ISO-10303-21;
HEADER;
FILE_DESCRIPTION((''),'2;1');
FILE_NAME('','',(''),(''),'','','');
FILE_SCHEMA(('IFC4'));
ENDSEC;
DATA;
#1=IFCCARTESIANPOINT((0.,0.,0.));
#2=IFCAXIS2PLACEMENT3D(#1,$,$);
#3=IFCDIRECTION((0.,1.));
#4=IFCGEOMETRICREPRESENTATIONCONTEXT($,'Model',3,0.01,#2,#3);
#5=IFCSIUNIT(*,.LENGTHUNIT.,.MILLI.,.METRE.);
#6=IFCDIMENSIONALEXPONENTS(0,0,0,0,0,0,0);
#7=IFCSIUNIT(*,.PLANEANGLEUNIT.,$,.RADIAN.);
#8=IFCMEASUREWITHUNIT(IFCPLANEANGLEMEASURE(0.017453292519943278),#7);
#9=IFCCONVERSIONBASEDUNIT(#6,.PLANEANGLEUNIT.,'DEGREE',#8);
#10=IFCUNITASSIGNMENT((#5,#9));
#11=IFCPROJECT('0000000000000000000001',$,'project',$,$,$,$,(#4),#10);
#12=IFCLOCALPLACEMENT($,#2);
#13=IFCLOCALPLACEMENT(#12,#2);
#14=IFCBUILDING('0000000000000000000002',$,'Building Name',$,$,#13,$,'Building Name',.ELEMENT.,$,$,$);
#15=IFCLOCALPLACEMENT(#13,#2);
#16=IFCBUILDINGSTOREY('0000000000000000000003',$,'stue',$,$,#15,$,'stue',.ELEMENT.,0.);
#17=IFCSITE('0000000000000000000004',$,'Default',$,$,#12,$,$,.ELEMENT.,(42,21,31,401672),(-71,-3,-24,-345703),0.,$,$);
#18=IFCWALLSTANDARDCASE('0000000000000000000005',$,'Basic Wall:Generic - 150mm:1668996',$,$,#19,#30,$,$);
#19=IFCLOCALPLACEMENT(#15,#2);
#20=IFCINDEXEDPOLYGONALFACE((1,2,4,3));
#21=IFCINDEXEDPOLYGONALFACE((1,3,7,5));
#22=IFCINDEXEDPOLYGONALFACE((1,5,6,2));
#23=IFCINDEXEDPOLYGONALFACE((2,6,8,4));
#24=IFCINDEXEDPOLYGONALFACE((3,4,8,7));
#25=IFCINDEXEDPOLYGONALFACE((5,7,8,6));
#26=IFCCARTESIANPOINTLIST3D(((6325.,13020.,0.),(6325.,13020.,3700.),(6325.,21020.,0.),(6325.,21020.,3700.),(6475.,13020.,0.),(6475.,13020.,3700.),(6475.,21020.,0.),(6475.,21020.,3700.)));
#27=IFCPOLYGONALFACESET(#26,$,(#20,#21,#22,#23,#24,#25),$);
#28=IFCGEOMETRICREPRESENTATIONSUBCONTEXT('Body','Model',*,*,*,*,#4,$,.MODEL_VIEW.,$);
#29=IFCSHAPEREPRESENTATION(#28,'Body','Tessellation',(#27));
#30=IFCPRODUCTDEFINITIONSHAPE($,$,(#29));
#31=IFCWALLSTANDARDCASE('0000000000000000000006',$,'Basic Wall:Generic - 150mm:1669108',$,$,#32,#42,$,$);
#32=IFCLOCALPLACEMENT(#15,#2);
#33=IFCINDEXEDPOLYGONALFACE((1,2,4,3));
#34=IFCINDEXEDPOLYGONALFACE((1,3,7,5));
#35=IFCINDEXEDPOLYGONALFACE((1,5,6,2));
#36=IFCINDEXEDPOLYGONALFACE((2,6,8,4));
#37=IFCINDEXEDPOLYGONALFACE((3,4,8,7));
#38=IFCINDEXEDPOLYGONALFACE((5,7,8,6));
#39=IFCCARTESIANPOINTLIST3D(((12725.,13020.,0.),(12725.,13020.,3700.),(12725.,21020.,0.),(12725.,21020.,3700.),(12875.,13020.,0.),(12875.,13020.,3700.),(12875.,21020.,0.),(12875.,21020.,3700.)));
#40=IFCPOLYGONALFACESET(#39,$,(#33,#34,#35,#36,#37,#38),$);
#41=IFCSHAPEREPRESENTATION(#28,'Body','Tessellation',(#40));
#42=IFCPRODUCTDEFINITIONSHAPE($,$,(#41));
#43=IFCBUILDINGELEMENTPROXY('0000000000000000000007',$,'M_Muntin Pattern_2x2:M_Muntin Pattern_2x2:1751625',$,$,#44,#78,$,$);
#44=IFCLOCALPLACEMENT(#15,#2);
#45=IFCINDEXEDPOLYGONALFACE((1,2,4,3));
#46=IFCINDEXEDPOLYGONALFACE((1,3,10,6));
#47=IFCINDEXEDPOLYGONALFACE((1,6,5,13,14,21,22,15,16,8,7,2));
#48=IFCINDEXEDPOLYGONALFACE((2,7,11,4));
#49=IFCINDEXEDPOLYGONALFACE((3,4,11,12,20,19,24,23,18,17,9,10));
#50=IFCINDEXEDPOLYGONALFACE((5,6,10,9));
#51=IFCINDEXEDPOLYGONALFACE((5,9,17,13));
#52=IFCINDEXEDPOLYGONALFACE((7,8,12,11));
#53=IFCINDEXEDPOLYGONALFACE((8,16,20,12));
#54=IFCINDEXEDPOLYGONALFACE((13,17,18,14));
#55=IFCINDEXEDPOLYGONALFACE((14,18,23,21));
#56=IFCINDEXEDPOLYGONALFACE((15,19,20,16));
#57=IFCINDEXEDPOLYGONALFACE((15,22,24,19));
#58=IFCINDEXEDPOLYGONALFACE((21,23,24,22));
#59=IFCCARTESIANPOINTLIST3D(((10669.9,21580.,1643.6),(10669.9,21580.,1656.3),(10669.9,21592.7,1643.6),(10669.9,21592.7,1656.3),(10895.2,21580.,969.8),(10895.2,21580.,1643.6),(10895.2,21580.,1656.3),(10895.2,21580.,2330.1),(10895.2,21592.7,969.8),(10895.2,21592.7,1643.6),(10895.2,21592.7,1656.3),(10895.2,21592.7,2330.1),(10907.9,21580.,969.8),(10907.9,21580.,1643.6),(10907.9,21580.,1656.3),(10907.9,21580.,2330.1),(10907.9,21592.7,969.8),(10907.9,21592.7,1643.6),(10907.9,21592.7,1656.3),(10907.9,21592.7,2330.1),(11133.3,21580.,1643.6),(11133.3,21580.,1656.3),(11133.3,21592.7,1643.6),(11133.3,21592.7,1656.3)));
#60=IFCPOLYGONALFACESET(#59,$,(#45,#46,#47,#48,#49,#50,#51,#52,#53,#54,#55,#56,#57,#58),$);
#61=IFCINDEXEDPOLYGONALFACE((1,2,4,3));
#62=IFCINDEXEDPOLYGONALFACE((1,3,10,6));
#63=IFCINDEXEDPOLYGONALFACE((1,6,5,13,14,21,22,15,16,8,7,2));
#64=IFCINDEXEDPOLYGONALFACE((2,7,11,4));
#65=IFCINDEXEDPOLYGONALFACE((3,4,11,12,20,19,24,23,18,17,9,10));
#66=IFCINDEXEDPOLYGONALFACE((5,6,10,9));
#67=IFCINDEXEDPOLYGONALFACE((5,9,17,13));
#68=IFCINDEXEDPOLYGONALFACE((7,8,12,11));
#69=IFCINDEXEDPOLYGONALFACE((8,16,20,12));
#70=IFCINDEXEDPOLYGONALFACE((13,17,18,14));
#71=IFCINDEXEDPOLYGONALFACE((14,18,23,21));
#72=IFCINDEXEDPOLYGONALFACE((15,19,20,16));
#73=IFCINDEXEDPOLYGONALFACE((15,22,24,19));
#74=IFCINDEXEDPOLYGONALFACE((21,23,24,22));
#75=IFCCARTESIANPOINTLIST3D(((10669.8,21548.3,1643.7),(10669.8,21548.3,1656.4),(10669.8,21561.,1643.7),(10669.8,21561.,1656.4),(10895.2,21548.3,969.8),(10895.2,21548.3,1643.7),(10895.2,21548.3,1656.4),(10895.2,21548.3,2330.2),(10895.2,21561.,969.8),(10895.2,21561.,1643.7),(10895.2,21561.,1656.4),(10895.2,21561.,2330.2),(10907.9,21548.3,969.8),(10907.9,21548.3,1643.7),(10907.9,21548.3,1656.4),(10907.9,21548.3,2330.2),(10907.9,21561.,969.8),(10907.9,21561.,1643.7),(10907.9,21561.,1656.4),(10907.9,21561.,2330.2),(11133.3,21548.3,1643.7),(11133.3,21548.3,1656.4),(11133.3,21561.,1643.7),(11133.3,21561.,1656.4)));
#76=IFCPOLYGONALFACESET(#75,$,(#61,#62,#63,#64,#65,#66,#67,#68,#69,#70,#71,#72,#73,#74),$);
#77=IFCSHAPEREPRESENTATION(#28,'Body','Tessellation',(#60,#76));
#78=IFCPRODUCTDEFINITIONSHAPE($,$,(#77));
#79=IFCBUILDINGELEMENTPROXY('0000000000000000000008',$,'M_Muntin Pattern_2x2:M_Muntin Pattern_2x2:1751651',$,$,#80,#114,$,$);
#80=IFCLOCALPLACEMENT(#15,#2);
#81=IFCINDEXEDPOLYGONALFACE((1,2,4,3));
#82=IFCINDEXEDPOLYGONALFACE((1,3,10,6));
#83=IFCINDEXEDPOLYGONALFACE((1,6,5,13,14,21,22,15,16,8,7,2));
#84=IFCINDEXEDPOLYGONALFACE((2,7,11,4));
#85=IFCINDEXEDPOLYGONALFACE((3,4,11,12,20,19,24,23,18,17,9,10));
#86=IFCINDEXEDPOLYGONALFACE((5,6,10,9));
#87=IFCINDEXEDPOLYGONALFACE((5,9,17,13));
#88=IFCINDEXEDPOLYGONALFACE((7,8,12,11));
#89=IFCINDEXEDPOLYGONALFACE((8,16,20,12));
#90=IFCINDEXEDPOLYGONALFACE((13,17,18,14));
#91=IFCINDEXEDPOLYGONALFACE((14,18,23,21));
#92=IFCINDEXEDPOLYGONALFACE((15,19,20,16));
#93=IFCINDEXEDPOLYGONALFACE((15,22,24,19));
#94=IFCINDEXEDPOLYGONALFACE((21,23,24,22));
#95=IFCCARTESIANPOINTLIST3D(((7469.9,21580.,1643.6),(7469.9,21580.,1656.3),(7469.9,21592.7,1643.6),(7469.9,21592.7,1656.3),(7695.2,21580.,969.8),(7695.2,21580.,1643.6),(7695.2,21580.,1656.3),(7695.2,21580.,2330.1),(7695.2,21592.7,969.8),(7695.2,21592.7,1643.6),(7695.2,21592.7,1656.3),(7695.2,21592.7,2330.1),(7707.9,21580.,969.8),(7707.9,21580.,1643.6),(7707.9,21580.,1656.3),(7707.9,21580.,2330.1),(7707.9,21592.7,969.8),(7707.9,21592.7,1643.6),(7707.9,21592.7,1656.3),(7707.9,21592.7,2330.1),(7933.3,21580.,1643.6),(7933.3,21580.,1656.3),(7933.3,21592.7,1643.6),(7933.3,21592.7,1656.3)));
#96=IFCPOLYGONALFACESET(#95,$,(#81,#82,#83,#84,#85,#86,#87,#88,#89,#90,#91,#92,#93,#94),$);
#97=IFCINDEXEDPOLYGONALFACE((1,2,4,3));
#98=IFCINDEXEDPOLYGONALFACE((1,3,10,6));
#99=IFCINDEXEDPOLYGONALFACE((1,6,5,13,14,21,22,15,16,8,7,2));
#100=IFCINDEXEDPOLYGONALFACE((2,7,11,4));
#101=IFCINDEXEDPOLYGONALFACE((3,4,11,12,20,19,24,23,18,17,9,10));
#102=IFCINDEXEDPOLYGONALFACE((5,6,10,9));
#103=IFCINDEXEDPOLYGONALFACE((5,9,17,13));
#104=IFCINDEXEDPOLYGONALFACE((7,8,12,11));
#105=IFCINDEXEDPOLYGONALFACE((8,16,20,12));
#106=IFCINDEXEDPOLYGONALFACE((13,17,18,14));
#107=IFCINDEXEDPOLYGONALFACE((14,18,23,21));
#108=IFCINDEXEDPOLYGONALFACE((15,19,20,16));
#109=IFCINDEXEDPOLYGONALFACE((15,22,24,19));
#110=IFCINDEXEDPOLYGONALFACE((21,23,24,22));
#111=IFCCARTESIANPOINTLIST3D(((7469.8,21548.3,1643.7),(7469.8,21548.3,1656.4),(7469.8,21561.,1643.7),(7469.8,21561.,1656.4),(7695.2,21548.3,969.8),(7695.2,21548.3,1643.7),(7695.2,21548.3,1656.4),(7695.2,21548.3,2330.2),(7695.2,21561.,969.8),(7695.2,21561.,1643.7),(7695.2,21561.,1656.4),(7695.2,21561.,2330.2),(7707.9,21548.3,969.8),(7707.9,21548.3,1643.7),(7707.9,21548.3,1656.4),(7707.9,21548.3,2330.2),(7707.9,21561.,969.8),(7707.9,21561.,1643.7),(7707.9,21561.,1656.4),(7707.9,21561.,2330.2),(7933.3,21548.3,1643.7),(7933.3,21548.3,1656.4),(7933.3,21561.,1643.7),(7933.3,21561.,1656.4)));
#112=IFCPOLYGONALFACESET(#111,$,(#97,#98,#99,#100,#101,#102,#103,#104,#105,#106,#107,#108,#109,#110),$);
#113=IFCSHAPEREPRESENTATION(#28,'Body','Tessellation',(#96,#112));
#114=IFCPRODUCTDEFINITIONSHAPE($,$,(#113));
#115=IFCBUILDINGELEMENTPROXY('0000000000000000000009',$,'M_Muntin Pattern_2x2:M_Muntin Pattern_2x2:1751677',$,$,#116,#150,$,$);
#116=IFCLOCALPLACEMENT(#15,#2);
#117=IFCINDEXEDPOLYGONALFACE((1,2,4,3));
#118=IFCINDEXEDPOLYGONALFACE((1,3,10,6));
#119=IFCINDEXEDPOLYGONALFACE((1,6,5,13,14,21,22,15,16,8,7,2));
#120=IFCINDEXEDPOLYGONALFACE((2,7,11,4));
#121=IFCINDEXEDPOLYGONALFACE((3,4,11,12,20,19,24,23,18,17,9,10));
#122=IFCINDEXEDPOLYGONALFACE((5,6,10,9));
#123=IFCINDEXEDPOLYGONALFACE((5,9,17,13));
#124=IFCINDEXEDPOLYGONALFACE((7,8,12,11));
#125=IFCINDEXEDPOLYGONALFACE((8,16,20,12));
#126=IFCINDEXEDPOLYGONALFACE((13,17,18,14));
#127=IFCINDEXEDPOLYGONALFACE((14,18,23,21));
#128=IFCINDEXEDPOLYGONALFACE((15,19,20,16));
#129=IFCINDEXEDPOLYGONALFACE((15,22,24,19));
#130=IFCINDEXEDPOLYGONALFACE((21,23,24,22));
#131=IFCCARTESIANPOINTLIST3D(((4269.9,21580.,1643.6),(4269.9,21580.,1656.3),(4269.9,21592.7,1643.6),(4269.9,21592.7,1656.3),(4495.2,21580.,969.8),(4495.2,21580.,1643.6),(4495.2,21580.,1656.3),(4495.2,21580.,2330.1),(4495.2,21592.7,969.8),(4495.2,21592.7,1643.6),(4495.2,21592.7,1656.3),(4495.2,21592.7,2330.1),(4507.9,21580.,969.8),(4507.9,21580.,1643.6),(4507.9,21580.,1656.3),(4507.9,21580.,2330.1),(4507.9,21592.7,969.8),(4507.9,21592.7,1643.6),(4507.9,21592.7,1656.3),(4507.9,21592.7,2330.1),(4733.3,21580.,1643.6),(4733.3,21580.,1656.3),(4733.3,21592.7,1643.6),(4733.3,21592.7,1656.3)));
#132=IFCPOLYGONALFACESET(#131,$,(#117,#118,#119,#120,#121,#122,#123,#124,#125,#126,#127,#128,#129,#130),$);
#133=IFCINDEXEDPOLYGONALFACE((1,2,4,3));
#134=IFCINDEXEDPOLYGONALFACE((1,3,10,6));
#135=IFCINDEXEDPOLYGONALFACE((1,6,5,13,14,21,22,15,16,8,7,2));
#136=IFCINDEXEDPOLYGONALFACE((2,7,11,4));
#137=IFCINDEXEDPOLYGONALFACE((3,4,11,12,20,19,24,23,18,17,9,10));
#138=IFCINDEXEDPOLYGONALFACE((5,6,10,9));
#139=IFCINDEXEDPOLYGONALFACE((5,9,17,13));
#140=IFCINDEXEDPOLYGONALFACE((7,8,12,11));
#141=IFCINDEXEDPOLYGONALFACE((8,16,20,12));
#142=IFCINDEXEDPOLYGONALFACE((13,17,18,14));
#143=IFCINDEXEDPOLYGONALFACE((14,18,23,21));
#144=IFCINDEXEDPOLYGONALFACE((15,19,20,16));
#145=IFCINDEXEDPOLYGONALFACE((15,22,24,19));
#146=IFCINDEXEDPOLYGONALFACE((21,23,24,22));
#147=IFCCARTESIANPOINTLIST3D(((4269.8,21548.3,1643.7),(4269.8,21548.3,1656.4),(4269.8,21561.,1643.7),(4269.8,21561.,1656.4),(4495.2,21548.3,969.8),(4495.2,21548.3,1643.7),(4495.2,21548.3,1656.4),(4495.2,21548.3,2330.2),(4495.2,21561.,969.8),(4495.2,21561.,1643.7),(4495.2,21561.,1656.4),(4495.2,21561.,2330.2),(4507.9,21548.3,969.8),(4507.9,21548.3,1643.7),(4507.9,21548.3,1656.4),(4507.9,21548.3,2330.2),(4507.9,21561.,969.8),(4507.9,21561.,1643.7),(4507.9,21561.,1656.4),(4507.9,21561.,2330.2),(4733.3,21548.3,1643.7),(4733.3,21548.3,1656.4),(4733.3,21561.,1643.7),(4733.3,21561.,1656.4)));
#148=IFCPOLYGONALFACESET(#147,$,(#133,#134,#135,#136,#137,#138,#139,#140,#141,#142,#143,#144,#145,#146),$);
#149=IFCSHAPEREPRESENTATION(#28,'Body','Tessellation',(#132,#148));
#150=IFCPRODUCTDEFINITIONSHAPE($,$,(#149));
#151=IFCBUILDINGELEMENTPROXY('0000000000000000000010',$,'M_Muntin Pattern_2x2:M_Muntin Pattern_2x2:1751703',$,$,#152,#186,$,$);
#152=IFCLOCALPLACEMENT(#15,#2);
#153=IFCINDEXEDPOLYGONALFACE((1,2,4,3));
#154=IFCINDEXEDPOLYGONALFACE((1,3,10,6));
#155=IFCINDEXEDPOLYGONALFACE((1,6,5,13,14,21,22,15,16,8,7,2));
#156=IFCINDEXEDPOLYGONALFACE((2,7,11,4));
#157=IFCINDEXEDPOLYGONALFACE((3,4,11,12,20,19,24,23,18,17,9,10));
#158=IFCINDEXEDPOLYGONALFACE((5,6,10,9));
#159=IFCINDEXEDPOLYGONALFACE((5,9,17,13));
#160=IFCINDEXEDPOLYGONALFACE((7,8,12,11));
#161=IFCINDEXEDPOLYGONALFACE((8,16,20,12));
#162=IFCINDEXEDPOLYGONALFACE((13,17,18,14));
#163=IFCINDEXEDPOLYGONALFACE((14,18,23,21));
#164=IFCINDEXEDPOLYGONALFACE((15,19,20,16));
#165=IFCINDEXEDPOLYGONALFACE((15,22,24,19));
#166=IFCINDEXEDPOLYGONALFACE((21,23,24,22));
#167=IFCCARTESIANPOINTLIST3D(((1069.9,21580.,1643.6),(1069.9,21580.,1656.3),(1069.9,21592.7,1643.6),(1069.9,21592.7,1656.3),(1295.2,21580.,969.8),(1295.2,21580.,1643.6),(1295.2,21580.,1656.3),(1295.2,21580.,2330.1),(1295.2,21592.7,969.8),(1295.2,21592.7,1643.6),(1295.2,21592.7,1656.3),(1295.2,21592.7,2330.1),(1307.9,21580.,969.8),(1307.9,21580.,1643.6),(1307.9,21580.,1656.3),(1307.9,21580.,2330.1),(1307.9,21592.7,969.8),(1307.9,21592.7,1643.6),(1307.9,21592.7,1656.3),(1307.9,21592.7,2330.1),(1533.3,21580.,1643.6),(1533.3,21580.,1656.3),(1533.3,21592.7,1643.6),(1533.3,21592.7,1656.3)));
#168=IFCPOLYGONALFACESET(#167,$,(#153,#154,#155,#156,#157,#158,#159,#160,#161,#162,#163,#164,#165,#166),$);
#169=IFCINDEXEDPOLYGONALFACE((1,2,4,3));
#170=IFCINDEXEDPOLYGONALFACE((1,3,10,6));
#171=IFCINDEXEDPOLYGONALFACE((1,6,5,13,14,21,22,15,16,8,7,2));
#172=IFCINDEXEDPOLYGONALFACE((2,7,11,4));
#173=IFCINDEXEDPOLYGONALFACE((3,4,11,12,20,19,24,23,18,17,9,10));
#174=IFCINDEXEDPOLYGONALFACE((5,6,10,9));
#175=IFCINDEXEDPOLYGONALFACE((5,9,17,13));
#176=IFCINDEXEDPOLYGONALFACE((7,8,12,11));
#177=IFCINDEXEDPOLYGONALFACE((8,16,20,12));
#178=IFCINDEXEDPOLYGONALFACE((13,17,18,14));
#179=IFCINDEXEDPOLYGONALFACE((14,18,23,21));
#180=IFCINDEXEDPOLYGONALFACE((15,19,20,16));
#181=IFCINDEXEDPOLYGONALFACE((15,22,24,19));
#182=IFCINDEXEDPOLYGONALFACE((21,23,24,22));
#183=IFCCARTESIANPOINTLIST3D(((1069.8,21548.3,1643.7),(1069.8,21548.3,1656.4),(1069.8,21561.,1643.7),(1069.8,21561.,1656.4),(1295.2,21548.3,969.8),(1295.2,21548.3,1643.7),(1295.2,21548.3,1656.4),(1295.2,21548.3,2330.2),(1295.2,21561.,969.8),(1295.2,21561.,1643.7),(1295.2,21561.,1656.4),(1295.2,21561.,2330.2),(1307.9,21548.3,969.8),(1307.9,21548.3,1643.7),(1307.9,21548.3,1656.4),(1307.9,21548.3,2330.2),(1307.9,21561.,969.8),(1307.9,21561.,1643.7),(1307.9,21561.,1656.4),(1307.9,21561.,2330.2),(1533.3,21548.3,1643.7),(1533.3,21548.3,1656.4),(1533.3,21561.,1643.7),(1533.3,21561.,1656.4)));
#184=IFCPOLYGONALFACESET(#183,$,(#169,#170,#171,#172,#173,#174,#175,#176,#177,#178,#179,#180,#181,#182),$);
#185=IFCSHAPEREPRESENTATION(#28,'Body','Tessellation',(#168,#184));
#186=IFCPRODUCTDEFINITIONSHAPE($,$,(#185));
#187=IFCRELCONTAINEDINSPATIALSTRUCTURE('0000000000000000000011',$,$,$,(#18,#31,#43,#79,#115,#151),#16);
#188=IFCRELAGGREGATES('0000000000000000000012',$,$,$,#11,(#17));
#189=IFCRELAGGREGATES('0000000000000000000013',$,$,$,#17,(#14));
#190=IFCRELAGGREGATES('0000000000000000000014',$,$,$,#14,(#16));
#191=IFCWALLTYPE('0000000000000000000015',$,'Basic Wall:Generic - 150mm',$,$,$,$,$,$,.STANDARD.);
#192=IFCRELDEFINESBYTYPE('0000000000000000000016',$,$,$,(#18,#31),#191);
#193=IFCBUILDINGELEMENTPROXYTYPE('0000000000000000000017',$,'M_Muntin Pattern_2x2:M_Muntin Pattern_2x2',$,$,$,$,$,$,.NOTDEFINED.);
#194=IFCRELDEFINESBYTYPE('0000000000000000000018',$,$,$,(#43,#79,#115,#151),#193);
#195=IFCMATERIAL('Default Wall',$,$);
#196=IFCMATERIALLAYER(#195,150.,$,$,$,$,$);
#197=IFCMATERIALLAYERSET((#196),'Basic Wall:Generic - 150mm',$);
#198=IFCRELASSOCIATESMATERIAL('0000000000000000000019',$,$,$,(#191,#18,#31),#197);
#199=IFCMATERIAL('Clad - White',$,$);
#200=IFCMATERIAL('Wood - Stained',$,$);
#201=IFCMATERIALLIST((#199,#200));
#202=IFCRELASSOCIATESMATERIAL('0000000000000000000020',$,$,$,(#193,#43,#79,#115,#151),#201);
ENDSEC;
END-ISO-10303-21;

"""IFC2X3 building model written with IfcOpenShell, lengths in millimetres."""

from ifc_helpers import new_model, entity, si_unit, converted_unit, direction, frame, frame_2d, origin, place, context, subcontext, project, spatial, polyline, rectangle, outline, extrude, clip, bounded_halfspace, source, transform, mapped, material, material_list, layer, layer_set, layer_usage, type_object, type_shapes, element, save


model = new_model("IFC2X3")

# Units and contexts
model_context = context("Model", 3, precision=0.01, world=origin(), true_north=direction((0.0, 1.0)))
body_context = subcontext(model_context, "Body", "Model", "MODEL_VIEW")
ifc_project = project(units=[si_unit("LENGTHUNIT", "METRE", prefix="MILLI"), converted_unit("PLANEANGLEUNIT", "DEGREE", entity("IfcPlaneAngleMeasure", 0.017453292519943278), si_unit("PLANEANGLEUNIT", "RADIAN"), dimensions=[0, 0, 0, 0, 0, 0, 0])], contexts=[model_context])

# Site, building, storey
site_placement = place(None, origin())
site = spatial("IfcSite", under=ifc_project, at=site_placement, Name="Default", CompositionType="ELEMENT", RefLatitude=(42, 21, 31, 401672), RefLongitude=(-71, -3, -24, -345703), RefElevation=0.0)
building_placement = place(site_placement, origin())
building = spatial("IfcBuilding", under=site, at=building_placement, Name="Building Name", LongName="Building Name", CompositionType="ELEMENT")
storey_placement = place(building_placement, origin())
storey = spatial("IfcBuildingStorey", under=building, at=storey_placement, Name="stue", LongName="stue", CompositionType="ELEMENT", Elevation=0.0)

# Walls
ifc_material_1 = material(Name="Default Wall")
ifc_layer = layer(ifc_material_1, 150.0)
ifc_layer_set = layer_set([ifc_layer], Name="Basic Wall:Generic - 150mm")
ifc_layer_usage_1 = layer_usage(ifc_layer_set, "AXIS2", "NEGATIVE", 75.0)
wall_type = type_object("IfcWallType", Name="Basic Wall:Generic - 150mm", PredefinedType="STANDARD", material=ifc_layer_set)
wall_1_placement = place(storey_placement, frame((6400.0, 21020.0, 0.0), z_axis=(0.0, 0.0, 1.0), x_axis=(0.0, -1.0, 0.0)))
element("IfcWallStandardCase", 1, at=wall_1_placement, inside=storey, type_object=wall_type, material=ifc_layer_usage_1, Name="Basic Wall:Generic - 150mm:1668996", context=body_context, shape_type="Clipping", body=[
    clip(extrude(rectangle(XDim=8000.0, YDim=150.0, at=frame_2d((4000.0, 0.0), x_axis=(-1.0, 0.0))), origin(), (0.0, 0.0, 1.0), 3700.0), bounded_halfspace(frame((0.0, -75.0, 3700.0), z_axis=(0.0, 0.0, -1.0), x_axis=(1.0, 0.0, 0.0)), True, frame((0.0, -75.0, 3700.0)), polyline([(0.0, 0.0), (8000.0, 0.0), (8000.0, 150.0), (0.0, 150.0), (0.0, 0.0)]))),
])
ifc_layer_usage_2 = layer_usage(ifc_layer_set, "AXIS2", "NEGATIVE", 75.0)
wall_2_placement = place(storey_placement, frame((12800.0, 21020.0, 0.0), z_axis=(0.0, 0.0, 1.0), x_axis=(0.0, -1.0, 0.0)))
element("IfcWallStandardCase", 2, at=wall_2_placement, inside=storey, type_object=wall_type, material=ifc_layer_usage_2, Name="Basic Wall:Generic - 150mm:1669108", context=body_context, shape_type="Clipping", body=[
    clip(extrude(rectangle(XDim=8000.0, YDim=150.0, at=frame_2d((4000.0, 0.0), x_axis=(-1.0, 0.0))), origin(), (0.0, 0.0, 1.0), 3700.0), bounded_halfspace(frame((0.0, -75.0, 3700.0), z_axis=(0.0, 0.0, -1.0), x_axis=(1.0, 0.0, 0.0)), True, frame((0.0, -75.0, 3700.0)), polyline([(0.0, 0.0), (8000.0, 0.0), (8000.0, 150.0), (6691.5, 150.0), (6594.5, 150.0), (1647.0, 150.0), (1533.0, 150.0), (0.0, 150.0), (0.0, 0.0)]))),
])

# Building element proxies
ifc_material_2 = material(Name="Clad - White")
ifc_material_3 = material(Name="Wood - Stained")
ifc_material_list = material_list([ifc_material_2, ifc_material_3])
building_element_proxy_type_1 = type_object("IfcBuildingElementProxyType", Name="M_Muntin Pattern_2x2:M_Muntin Pattern_2x2", PredefinedType="NOTDEFINED", material=ifc_material_list)
shared_shape_1 = source(origin(), body_context, "Body", "SweptSolid", [
    extrude(outline(polyline([(6.4, -6.4), (680.1, -6.4), (680.1, 6.3), (6.4, 6.3), (6.4, 231.7), (-6.3, 231.7), (-6.3, 6.3), (-680.2, 6.3), (-680.2, -6.4), (-6.3, -6.4), (-6.3, -231.7), (6.4, -231.7), (6.4, -6.4)])), frame((0.0, 9.5, 680.1), z_axis=(0.0, 1.0, 0.0), x_axis=(0.0, 0.0, 1.0)), (0.0, 0.0, 1.0), 12.7),
    extrude(outline(polyline([(6.4, -6.4), (680.2, -6.4), (680.2, 6.3), (6.4, 6.3), (6.4, 231.7), (-6.3, 231.7), (-6.3, 6.3), (-680.2, 6.3), (-680.2, -6.4), (-6.3, -6.4), (-6.3, -231.7), (6.4, -231.7), (6.4, -6.4)])), frame((0.0, -22.2, 680.2), z_axis=(0.0, 1.0, 0.0), x_axis=(0.0, 0.0, 1.0)), (0.0, 0.0, 1.0), 12.7),
])
type_shapes(building_element_proxy_type_1, [shared_shape_1])
for number, where, name in (
    (3, (10901.6, 21570.5, 969.8), "M_Muntin Pattern_2x2:M_Muntin Pattern_2x2:1751625"),
    (4, (7701.6, 21570.5, 969.8), "M_Muntin Pattern_2x2:M_Muntin Pattern_2x2:1751651"),
    (5, (4501.6, 21570.5, 969.8), "M_Muntin Pattern_2x2:M_Muntin Pattern_2x2:1751677"),
    (6, (1301.6, 21570.5, 969.8), "M_Muntin Pattern_2x2:M_Muntin Pattern_2x2:1751703"),
):
    element("IfcBuildingElementProxy", number, at=place(storey_placement, frame(where)), inside=storey, type_object=building_element_proxy_type_1, material=ifc_material_list, Name=name, context=body_context, shape_type="MappedRepresentation", body=[
        mapped(shared_shape_1, transform((0.0, 0.0, 0.0), scale=1.0)),
    ])

save(model, "model.ifc")
